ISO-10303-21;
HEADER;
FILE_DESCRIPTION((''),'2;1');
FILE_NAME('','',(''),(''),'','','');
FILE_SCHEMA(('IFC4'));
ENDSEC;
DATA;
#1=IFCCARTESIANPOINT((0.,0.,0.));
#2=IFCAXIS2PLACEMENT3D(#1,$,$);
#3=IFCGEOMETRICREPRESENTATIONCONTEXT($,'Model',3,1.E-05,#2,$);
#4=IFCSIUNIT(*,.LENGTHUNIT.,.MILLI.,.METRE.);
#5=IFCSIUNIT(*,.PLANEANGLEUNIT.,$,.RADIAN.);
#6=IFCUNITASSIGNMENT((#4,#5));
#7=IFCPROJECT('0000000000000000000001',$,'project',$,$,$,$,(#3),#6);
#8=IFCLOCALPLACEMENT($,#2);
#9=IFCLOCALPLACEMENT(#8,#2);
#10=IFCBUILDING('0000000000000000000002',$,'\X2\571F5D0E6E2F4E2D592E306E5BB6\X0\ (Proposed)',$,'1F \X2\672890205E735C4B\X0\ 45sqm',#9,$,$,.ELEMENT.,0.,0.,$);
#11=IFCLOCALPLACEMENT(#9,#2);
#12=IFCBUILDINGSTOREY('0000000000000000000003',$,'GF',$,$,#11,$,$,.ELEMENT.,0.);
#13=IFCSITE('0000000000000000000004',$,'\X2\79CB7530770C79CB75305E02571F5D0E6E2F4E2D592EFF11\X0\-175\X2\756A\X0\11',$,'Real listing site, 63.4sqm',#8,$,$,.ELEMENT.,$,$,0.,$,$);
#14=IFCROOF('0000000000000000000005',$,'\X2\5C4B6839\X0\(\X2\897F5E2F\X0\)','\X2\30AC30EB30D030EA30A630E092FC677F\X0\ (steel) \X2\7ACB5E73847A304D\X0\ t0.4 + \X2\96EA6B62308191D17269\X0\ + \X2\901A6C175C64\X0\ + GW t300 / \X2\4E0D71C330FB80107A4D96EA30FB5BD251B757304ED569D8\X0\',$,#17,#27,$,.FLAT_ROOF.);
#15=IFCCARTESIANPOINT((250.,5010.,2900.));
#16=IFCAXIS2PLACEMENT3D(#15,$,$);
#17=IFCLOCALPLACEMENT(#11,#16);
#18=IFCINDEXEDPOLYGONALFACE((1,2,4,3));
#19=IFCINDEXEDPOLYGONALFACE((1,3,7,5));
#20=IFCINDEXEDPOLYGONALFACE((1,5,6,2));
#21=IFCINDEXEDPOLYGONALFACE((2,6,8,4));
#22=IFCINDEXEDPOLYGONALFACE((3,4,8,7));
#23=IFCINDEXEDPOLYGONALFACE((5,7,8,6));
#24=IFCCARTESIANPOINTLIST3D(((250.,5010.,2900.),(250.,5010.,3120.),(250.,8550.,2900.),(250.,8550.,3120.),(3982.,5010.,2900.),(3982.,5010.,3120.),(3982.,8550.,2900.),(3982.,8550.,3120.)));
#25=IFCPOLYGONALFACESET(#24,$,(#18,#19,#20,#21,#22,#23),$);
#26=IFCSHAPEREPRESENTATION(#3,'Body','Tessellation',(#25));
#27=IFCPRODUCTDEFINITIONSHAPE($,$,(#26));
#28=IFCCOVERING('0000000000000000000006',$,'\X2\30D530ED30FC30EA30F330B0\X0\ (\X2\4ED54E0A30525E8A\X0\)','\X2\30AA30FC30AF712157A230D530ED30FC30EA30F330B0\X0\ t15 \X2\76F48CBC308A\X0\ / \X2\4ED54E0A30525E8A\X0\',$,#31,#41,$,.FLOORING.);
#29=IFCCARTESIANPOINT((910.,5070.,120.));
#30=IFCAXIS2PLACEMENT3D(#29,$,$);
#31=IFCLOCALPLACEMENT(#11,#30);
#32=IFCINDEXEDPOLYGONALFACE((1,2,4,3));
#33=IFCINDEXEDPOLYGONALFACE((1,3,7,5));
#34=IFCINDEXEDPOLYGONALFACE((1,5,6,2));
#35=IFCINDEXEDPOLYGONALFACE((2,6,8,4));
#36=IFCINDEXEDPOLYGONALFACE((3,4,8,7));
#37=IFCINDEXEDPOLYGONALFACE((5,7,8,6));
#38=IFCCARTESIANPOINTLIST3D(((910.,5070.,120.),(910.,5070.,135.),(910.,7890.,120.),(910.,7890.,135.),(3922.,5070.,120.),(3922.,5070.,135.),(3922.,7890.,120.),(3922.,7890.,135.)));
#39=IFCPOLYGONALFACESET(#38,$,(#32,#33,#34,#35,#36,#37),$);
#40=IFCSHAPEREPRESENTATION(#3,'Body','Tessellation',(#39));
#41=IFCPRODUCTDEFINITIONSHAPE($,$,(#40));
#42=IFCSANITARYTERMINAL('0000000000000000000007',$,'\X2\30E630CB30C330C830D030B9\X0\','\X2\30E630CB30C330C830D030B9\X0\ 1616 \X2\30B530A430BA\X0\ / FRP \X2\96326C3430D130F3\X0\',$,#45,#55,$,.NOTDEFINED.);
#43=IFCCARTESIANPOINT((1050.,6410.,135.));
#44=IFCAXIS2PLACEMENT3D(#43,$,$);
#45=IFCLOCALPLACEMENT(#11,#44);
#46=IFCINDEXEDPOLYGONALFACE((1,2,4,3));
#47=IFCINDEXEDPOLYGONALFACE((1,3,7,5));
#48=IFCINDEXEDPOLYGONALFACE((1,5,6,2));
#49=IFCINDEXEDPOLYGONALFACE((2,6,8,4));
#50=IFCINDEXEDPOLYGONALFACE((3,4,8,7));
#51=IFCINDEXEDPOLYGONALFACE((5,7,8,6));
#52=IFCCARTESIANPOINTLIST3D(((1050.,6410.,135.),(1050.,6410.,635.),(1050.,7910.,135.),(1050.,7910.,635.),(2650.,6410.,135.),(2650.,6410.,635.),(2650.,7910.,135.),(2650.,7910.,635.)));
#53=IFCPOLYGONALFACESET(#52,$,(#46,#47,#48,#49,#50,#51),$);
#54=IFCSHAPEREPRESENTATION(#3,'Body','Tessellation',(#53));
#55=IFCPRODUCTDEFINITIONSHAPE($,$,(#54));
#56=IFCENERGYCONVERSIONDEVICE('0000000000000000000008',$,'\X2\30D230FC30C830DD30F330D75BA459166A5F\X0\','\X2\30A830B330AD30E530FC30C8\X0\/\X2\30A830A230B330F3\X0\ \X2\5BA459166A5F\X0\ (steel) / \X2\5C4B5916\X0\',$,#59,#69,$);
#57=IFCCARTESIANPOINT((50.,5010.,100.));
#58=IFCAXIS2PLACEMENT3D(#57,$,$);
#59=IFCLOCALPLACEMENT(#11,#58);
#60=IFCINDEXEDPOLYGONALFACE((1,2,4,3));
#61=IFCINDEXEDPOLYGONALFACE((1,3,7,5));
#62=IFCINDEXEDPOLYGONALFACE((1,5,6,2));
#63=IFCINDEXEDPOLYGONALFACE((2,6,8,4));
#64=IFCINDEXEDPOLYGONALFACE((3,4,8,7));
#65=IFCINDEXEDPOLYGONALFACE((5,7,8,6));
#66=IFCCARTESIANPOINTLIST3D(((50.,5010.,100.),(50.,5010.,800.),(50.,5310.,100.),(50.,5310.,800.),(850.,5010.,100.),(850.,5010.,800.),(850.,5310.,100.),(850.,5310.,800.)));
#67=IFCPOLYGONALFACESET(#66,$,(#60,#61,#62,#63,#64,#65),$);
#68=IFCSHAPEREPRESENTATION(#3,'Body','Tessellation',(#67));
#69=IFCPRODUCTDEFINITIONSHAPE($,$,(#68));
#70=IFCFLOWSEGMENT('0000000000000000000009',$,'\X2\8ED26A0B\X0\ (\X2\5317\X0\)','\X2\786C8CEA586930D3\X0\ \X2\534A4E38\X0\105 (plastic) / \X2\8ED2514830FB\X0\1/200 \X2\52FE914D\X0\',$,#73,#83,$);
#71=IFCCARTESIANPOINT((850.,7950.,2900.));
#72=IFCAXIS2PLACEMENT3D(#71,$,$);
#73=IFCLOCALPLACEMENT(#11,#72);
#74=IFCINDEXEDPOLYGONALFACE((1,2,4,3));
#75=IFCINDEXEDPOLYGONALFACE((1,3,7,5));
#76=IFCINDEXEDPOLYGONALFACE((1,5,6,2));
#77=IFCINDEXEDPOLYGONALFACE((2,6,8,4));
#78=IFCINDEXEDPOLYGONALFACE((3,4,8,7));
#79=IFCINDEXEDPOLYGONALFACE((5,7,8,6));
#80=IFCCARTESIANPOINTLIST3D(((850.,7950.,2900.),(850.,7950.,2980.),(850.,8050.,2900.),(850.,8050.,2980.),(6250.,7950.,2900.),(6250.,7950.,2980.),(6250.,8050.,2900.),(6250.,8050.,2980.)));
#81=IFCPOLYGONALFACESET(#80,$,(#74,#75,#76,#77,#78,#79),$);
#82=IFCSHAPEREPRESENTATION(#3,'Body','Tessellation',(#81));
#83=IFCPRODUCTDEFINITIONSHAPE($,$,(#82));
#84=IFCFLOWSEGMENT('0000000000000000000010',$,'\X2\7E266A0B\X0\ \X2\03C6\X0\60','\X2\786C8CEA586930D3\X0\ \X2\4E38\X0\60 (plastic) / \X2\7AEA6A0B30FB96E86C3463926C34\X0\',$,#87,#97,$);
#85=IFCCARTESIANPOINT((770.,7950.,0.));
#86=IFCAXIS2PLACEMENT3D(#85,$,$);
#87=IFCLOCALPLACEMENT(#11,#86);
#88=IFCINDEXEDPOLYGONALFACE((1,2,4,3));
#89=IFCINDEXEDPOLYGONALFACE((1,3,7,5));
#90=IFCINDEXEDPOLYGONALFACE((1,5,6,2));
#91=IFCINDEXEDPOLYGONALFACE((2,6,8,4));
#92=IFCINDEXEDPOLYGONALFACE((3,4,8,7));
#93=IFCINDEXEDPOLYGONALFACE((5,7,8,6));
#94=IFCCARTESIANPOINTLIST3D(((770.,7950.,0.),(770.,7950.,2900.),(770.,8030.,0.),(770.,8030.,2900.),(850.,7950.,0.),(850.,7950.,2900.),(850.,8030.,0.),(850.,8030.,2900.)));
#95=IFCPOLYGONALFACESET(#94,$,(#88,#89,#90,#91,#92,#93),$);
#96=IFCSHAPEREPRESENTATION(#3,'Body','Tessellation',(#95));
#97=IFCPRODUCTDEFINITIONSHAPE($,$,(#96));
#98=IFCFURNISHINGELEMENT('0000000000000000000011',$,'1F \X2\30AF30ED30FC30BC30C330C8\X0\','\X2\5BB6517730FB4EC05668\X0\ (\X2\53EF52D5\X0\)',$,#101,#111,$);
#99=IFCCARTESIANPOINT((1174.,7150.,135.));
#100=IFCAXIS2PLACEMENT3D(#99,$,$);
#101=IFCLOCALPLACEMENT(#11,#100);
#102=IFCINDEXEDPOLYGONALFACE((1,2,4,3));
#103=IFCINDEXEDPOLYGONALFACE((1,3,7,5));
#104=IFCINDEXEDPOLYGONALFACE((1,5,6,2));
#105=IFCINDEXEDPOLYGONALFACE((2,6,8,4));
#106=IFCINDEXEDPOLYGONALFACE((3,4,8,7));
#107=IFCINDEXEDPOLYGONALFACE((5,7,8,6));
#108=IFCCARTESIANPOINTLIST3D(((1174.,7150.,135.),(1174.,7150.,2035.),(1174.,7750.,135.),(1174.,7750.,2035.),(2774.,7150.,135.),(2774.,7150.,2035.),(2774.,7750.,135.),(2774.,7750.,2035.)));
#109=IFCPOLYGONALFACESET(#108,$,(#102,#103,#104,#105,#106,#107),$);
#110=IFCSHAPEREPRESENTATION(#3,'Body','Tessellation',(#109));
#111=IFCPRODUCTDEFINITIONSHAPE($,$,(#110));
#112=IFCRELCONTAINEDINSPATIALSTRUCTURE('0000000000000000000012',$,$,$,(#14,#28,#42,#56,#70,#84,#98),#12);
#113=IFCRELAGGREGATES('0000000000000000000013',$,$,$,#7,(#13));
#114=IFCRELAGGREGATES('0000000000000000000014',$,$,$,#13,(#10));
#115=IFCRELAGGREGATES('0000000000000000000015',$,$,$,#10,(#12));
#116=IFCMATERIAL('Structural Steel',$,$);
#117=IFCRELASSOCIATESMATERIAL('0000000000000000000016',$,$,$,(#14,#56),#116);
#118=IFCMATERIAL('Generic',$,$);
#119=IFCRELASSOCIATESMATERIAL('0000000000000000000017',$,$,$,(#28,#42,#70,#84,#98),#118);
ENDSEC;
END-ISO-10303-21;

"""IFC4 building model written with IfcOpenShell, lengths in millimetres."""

from ifc_helpers import new_model, si_unit, frame, frame_2d, origin, place, context, project, spatial, rectangle, extrude, material, element, save


model = new_model("IFC4")

# Units and contexts
model_context = context("Model", 3, precision=1e-05, world=origin())
ifc_project = project(units=[si_unit("LENGTHUNIT", "METRE", prefix="MILLI"), si_unit("PLANEANGLEUNIT", "RADIAN")], contexts=[model_context])

# Site, building, storey
site_placement = place(None, origin())
site = spatial("IfcSite", under=ifc_project, at=site_placement, Name="秋田県秋田市土崎港中央１-175番11", ObjectType="Real listing site, 63.4sqm", CompositionType="ELEMENT", RefElevation=0.0)
building_placement = place(site_placement, origin())
building = spatial("IfcBuilding", under=site, at=building_placement, Name="土崎港中央の家 (Proposed)", ObjectType="1F 木造平屋 45sqm", CompositionType="ELEMENT", ElevationOfRefHeight=0.0, ElevationOfTerrain=0.0)
storey_placement = place(building_placement, origin())
storey = spatial("IfcBuildingStorey", under=building, at=storey_placement, Name="GF", CompositionType="ELEMENT", Elevation=0.0)

# Roof
ifc_material_1 = material(Name="Structural Steel")
roof_placement = place(storey_placement, frame((250.0, 5010.0, 2900.0)))
element("IfcRoof", 1, at=roof_placement, inside=storey, material=ifc_material_1, Name="屋根(西帯)", Description="ガルバリウム鋼板 (steel) 立平葺き t0.4 + 雪止め金物 + 通気層 + GW t300 / 不燃・耐積雪・寒冷地仕様", PredefinedType="FLAT_ROOF", context=model_context, shape_type="SweptSolid", body=[
    extrude(rectangle(XDim=3732.0, YDim=3540.0, at=frame_2d((1866.0, 1770.0))), frame((250.0, 5010.0, 2900.0)), (0.0, 0.0, 1.0), 220.0),
])

# Covering
ifc_material_2 = material(Name="Generic")
covering_placement = place(storey_placement, frame((910.0, 5070.0, 120.0)))
element("IfcCovering", 2, at=covering_placement, inside=storey, material=ifc_material_2, Name="フローリング (仕上げ床)", Description="オーク無垢フローリング t15 直貼り / 仕上げ床", PredefinedType="FLOORING", context=model_context, shape_type="SweptSolid", body=[
    extrude(rectangle(XDim=3012.0, YDim=2820.0, at=frame_2d((1506.0, 1410.0))), frame((910.0, 5070.0, 120.0)), (0.0, 0.0, 1.0), 15.0),
])

# Sanitary terminal
sanitary_terminal_placement = place(storey_placement, frame((1050.0, 6410.0, 135.0)))
element("IfcSanitaryTerminal", 3, at=sanitary_terminal_placement, inside=storey, material=ifc_material_2, Name="ユニットバス", Description="ユニットバス 1616 サイズ / FRP 防水パン", PredefinedType="NOTDEFINED", context=model_context, shape_type="SweptSolid", body=[
    extrude(rectangle(XDim=1600.0, YDim=1500.0, at=frame_2d((800.0, 750.0))), frame((1050.0, 6410.0, 135.0)), (0.0, 0.0, 1.0), 500.0),
])

# Energy conversion device
energy_conversion_device_placement = place(storey_placement, frame((50.0, 5010.0, 100.0)))
element("IfcEnergyConversionDevice", 4, at=energy_conversion_device_placement, inside=storey, material=ifc_material_1, Name="ヒートポンプ室外機", Description="エコキュート/エアコン 室外機 (steel) / 屋外", context=model_context, shape_type="SweptSolid", body=[
    extrude(rectangle(XDim=800.0, YDim=300.0, at=frame_2d((400.0, 150.0))), frame((50.0, 5010.0, 100.0)), (0.0, 0.0, 1.0), 700.0),
])

# Flow segments
flow_segment_1_placement = place(storey_placement, frame((850.0, 7950.0, 2900.0)))
element("IfcFlowSegment", 5, at=flow_segment_1_placement, inside=storey, material=ifc_material_2, Name="軒樋 (北)", Description="硬質塩ビ 半丸105 (plastic) / 軒先・1/200 勾配", context=model_context, shape_type="SweptSolid", body=[
    extrude(rectangle(XDim=5400.0, YDim=100.0, at=frame_2d((2700.0, 50.0))), frame((850.0, 7950.0, 2900.0)), (0.0, 0.0, 1.0), 80.0),
])
flow_segment_2_placement = place(storey_placement, frame((770.0, 7950.0, 0.0)))
element("IfcFlowSegment", 6, at=flow_segment_2_placement, inside=storey, material=ifc_material_2, Name="縦樋 φ60", Description="硬質塩ビ 丸60 (plastic) / 竪樋・雨水排水", context=model_context, shape_type="SweptSolid", body=[
    extrude(rectangle(XDim=80.0, YDim=80.0, at=frame_2d((40.0, 40.0))), frame((770.0, 7950.0, 0.0)), (0.0, 0.0, 1.0), 2900.0),
])

# Furnishing element
furnishing_placement = place(storey_placement, frame((1174.0, 7150.0, 135.0)))
element("IfcFurnishingElement", 7, at=furnishing_placement, inside=storey, material=ifc_material_2, Name="1F クローゼット", Description="家具・什器 (可動)", context=model_context, shape_type="SweptSolid", body=[
    extrude(rectangle(XDim=1600.0, YDim=600.0, at=frame_2d((800.0, 300.0))), frame((1174.0, 7150.0, 135.0)), (0.0, 0.0, 1.0), 1900.0),
])

save(model, "model.ifc")
